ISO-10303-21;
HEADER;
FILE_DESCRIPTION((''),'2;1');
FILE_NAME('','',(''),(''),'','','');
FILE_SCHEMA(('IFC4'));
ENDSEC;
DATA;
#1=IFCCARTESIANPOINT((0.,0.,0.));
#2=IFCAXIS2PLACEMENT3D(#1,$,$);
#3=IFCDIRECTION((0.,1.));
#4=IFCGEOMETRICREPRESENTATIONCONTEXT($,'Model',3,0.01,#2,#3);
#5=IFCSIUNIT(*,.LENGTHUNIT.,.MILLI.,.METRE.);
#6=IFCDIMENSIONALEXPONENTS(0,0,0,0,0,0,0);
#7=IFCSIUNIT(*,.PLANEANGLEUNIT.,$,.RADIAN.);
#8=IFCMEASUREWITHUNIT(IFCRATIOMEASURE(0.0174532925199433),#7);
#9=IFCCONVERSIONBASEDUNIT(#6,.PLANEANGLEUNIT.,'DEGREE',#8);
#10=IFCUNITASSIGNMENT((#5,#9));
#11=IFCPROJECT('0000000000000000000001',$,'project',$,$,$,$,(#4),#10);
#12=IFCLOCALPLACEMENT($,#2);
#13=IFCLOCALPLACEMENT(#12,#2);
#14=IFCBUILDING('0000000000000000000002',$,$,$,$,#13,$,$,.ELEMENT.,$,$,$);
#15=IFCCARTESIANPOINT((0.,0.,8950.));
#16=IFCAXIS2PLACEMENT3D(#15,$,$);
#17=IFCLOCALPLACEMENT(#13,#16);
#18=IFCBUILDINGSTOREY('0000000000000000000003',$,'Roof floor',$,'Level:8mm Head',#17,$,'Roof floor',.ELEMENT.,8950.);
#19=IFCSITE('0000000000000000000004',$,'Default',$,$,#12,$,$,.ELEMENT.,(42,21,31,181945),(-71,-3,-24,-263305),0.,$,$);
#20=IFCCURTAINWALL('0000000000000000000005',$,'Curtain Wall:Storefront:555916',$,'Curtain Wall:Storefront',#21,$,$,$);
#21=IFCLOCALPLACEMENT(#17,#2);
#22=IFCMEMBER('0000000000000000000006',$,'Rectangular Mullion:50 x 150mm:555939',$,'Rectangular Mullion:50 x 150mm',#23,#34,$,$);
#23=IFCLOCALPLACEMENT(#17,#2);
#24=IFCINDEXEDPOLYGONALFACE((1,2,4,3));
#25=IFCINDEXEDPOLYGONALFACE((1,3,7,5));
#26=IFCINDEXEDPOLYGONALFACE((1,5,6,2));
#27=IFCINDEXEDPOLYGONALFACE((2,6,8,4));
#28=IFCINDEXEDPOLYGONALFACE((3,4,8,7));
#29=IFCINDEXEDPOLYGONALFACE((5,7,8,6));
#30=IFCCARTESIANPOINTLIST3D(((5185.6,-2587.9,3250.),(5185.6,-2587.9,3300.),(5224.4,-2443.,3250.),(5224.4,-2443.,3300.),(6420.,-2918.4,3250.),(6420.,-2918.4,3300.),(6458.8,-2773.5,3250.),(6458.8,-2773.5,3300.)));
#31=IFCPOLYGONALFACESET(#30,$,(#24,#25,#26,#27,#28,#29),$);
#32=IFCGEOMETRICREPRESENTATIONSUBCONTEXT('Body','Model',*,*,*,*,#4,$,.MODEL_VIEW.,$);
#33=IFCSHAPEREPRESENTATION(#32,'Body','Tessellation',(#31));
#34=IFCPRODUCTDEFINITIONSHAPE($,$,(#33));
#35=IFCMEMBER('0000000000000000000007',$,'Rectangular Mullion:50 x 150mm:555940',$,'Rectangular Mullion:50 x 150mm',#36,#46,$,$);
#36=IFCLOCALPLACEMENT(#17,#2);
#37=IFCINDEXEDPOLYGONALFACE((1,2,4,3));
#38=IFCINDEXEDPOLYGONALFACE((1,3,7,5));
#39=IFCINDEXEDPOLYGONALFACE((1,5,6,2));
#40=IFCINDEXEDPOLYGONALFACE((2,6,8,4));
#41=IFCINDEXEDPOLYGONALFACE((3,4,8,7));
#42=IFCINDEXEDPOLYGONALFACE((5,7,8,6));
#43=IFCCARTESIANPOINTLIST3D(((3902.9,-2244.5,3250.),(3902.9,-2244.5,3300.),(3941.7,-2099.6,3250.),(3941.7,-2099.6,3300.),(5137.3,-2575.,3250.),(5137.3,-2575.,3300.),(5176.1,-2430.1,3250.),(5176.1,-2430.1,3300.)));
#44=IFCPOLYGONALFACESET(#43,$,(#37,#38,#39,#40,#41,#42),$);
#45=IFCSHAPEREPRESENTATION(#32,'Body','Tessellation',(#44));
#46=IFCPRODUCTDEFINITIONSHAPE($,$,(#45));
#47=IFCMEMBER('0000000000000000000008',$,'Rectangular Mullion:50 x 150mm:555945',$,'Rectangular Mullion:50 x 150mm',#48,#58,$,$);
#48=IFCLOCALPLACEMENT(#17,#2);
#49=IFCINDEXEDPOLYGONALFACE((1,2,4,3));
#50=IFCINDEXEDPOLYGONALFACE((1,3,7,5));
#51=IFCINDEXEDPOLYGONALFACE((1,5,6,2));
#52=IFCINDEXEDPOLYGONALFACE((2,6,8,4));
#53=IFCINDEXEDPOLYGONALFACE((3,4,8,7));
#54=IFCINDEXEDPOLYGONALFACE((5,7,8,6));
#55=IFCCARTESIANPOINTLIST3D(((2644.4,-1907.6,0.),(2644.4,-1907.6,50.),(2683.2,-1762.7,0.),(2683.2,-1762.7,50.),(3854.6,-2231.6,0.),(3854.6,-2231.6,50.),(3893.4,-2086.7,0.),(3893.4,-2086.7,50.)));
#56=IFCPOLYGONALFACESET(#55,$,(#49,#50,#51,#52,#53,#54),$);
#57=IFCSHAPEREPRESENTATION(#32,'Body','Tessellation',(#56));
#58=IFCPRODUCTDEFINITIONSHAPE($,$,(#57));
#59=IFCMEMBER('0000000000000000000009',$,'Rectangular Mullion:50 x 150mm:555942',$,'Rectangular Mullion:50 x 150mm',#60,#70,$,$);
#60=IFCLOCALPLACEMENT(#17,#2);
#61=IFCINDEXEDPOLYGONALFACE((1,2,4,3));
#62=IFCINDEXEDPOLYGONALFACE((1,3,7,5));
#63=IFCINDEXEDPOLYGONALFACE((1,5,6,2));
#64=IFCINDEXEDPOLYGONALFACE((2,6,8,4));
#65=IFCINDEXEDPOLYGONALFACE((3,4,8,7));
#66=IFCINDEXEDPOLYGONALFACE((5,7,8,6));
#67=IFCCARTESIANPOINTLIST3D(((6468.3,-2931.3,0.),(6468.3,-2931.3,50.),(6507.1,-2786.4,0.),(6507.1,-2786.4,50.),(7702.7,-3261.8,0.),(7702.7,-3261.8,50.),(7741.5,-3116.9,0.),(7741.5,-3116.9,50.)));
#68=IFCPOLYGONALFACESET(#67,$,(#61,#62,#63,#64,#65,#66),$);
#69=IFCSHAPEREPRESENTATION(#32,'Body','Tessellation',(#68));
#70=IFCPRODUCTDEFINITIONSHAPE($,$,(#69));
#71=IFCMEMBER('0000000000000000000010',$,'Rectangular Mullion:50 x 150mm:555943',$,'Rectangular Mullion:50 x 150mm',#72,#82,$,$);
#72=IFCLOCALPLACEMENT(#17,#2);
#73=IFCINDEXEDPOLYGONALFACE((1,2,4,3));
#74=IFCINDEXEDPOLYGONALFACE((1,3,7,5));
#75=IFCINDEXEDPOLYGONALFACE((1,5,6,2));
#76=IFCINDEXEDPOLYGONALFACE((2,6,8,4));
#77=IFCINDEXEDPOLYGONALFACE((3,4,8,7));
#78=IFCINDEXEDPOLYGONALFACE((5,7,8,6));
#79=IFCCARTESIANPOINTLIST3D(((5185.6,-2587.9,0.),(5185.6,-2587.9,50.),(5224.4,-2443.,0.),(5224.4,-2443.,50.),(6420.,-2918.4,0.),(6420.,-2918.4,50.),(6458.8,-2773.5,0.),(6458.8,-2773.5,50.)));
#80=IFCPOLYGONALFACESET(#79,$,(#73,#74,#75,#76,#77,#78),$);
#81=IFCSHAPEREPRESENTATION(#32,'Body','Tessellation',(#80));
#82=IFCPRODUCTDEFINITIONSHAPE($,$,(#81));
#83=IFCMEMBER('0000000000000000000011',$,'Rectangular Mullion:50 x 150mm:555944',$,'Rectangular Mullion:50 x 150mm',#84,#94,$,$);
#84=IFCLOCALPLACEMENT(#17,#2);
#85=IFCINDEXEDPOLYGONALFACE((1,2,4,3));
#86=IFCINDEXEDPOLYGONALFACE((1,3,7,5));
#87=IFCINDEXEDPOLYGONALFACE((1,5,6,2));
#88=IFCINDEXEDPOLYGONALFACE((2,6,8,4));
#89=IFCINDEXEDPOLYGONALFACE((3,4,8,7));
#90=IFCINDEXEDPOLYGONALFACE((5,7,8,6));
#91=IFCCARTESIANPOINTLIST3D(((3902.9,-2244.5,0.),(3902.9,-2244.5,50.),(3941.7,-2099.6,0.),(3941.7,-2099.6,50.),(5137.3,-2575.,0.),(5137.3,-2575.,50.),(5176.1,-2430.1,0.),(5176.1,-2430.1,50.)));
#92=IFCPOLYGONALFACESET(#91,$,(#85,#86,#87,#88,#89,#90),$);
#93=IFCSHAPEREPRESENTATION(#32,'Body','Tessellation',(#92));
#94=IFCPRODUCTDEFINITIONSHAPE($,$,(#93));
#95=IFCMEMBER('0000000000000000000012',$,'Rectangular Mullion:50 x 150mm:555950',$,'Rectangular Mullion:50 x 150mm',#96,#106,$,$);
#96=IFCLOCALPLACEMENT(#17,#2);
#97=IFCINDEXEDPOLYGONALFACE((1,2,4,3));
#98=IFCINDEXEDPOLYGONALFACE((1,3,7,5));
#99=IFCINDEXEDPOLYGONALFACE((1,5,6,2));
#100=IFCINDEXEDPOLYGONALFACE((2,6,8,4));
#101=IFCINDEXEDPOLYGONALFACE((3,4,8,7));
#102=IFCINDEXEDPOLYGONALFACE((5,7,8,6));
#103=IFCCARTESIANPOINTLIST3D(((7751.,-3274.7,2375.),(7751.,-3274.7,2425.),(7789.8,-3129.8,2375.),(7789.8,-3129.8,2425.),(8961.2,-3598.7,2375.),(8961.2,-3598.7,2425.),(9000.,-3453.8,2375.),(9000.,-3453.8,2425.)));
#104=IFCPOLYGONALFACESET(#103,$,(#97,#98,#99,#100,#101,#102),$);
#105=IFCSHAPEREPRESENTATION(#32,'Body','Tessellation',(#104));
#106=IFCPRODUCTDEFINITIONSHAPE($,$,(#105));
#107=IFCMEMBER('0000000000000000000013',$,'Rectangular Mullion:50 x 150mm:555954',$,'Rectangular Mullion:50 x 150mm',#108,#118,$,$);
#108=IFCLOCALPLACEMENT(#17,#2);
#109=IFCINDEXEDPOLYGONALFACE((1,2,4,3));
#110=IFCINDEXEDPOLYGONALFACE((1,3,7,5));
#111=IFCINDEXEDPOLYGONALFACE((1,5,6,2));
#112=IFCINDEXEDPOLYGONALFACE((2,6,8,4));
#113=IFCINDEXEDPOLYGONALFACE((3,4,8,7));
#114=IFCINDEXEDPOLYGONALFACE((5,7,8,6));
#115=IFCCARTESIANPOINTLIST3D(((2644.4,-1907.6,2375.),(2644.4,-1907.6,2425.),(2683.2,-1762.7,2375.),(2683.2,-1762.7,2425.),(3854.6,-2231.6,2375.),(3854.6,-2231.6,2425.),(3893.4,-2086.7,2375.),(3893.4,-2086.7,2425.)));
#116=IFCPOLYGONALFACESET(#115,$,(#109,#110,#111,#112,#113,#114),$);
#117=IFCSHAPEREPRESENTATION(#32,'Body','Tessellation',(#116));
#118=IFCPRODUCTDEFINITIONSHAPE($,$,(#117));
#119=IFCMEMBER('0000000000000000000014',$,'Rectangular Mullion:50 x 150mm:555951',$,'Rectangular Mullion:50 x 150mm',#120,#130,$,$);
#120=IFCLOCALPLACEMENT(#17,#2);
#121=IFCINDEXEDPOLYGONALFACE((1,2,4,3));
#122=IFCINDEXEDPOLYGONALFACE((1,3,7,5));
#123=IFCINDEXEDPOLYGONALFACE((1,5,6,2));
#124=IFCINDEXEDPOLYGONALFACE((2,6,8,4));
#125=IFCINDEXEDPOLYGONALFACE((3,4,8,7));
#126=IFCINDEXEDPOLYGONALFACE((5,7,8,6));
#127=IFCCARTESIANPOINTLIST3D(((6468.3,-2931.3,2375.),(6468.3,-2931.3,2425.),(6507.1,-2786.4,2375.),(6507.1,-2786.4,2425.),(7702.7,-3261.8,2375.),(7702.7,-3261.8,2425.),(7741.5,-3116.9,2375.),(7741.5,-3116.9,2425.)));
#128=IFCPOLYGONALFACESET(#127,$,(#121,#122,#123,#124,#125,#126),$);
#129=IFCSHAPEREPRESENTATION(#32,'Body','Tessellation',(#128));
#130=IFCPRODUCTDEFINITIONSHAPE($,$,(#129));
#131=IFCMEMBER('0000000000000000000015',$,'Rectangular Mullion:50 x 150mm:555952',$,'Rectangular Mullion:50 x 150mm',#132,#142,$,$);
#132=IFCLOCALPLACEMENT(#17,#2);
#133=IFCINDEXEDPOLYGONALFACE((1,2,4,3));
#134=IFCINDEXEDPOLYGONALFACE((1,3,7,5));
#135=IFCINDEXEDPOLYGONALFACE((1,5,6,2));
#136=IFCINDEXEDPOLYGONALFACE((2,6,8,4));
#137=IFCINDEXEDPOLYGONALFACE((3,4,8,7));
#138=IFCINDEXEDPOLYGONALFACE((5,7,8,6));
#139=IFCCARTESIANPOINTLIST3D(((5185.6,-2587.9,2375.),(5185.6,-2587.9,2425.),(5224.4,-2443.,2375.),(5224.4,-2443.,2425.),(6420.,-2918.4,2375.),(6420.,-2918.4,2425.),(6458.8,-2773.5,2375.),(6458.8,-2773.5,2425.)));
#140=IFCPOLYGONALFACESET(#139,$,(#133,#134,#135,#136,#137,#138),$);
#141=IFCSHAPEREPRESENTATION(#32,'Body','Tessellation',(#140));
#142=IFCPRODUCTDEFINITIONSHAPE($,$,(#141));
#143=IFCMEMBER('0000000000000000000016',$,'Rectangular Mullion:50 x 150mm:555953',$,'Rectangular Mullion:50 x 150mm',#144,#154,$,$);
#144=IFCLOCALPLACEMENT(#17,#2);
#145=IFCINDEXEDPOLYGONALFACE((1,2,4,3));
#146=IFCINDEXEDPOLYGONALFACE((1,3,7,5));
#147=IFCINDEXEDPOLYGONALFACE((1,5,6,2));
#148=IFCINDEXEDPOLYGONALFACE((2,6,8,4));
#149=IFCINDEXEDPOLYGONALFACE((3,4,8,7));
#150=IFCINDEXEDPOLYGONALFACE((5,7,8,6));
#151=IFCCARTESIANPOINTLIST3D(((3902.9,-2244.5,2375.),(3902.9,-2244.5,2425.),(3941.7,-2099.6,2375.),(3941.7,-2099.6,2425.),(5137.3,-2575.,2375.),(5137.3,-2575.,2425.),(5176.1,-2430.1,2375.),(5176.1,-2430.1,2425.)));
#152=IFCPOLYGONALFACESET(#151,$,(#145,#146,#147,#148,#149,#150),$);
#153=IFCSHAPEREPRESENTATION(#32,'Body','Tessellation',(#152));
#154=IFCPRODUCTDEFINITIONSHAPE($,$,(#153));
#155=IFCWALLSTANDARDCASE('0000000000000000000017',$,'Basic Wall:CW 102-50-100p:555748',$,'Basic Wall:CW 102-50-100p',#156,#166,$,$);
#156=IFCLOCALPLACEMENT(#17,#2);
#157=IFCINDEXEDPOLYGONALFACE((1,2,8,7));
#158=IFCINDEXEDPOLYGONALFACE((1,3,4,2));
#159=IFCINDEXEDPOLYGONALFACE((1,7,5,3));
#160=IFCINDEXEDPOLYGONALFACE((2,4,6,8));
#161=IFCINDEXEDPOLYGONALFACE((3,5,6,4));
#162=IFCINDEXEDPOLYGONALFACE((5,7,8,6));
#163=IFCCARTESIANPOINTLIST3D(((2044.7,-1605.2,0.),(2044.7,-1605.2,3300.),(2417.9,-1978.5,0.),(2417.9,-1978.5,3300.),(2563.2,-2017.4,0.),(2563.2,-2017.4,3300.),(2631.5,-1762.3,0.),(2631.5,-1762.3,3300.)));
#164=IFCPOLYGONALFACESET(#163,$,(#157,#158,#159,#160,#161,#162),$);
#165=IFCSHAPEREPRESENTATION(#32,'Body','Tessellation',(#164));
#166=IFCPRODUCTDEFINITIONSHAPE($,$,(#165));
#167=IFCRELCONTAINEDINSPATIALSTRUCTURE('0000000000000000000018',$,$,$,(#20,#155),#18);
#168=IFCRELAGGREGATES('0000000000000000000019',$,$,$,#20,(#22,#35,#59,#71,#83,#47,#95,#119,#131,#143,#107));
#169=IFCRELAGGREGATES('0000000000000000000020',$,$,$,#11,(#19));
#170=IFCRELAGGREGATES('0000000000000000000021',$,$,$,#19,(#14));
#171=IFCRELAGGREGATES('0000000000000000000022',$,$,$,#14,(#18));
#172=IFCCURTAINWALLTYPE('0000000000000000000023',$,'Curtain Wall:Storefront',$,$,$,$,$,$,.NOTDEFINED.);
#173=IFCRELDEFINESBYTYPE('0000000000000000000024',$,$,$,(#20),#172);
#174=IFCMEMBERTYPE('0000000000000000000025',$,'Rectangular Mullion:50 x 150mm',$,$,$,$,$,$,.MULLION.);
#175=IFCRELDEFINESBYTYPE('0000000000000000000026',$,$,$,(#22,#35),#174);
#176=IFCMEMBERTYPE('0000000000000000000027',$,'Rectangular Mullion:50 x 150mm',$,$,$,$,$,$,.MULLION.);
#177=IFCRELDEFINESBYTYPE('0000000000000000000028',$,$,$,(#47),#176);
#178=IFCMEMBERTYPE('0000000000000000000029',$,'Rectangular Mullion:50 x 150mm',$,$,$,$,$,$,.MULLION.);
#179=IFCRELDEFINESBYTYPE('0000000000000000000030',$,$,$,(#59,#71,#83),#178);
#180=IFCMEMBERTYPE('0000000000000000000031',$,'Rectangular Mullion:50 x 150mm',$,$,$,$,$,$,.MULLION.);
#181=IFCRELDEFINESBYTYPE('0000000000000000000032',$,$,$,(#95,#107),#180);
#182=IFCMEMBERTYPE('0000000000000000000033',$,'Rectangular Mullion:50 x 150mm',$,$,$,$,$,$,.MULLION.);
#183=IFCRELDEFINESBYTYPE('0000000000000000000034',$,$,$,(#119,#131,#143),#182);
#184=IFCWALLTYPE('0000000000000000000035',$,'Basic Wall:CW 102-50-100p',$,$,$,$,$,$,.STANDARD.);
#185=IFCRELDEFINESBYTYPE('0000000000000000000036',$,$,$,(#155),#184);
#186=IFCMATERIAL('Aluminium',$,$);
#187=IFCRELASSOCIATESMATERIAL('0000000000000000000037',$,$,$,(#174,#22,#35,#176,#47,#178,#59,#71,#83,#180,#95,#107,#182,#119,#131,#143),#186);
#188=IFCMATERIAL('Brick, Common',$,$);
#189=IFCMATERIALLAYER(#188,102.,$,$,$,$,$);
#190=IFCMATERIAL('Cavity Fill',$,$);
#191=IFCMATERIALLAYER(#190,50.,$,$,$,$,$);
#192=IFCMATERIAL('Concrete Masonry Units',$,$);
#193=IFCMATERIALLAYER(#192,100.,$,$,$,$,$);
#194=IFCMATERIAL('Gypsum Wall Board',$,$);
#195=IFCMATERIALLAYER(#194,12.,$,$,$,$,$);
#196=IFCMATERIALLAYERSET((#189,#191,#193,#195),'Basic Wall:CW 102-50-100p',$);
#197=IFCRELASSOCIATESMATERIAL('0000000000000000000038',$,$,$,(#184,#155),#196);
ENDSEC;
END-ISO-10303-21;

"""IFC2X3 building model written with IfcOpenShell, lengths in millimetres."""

from ifc_helpers import new_model, entity, si_unit, converted_unit, direction, frame, origin, origin_2d_with_axis, place, context, subcontext, project, spatial, polyline, rectangle, outline, extrude, source, transform, mapped, material, layer, layer_set, layer_usage, type_object, type_shapes, element, aggregate, save


model = new_model("IFC2X3")

# Units and contexts
model_context = context("Model", 3, precision=0.01, world=origin(), true_north=direction((0.0, 1.0)))
body_context = subcontext(model_context, "Body", "Model", "MODEL_VIEW")
ifc_project = project(units=[si_unit("LENGTHUNIT", "METRE", prefix="MILLI"), converted_unit("PLANEANGLEUNIT", "DEGREE", entity("IfcRatioMeasure", 0.0174532925199433), si_unit("PLANEANGLEUNIT", "RADIAN"), dimensions=[0, 0, 0, 0, 0, 0, 0])], contexts=[model_context])

# Site, building, storey
site_placement = place(None, origin())
site = spatial("IfcSite", under=ifc_project, at=site_placement, Name="Default", CompositionType="ELEMENT", RefLatitude=(42, 21, 31, 181945), RefLongitude=(-71, -3, -24, -263305), RefElevation=0.0)
building_placement = place(site_placement, origin())
building = spatial("IfcBuilding", under=site, at=building_placement, CompositionType="ELEMENT")
storey_placement = place(building_placement, frame((0.0, 0.0, 8950.0)))
storey = spatial("IfcBuildingStorey", under=building, at=storey_placement, Name="Roof floor", ObjectType="Level:8mm Head", LongName="Roof floor", CompositionType="ELEMENT", Elevation=8950.0)

# Curtain wall, members
curtain_wall_type = type_object("IfcCurtainWallType", Name="Curtain Wall:Storefront", PredefinedType="NOTDEFINED")
curtain_wall_placement = place(storey_placement, frame((0.0, 0.0, -8950.0)))
curtain_wall = element("IfcCurtainWall", 1, at=curtain_wall_placement, inside=storey, type_object=curtain_wall_type, Name="Curtain Wall:Storefront:555916", ObjectType="Curtain Wall:Storefront")
ifc_material_1 = material(Name="Aluminium")
member_type_1 = type_object("IfcMemberType", Name="Rectangular Mullion:50 x 150mm", PredefinedType="MULLION", material=ifc_material_1)
shared_shape_1 = source(origin(), body_context, "Body", "SweptSolid", [
    extrude(rectangle(XDim=150.0, YDim=50.0, at=origin_2d_with_axis()), frame((-25.0, 0.0, -1277.9), z_axis=(0.0, 0.0, 1.0), x_axis=(0.0, -1.0, 0.0)), (0.0, 0.0, 1.0), 1277.9),
])
type_shapes(member_type_1, [shared_shape_1])
member_1_placement = place(storey_placement, frame((5205.0, -2515.5, 3300.0), z_axis=(-0.965983, 0.258607, 0.0), x_axis=(0.0, 0.0, 1.0)))
member_1 = element("IfcMember", 2, at=member_1_placement, type_object=member_type_1, material=ifc_material_1, Name="Rectangular Mullion:50 x 150mm:555939", ObjectType="Rectangular Mullion:50 x 150mm", context=body_context, shape_type="MappedRepresentation", body=[
    mapped(shared_shape_1, transform((0.0, 0.0, 0.0), scale=1.0)),
])
member_2_placement = place(storey_placement, frame((3922.3, -2172.1, 3300.0), z_axis=(-0.965983, 0.258607, 0.0), x_axis=(0.0, 0.0, 1.0)))
member_2 = element("IfcMember", 3, at=member_2_placement, type_object=member_type_1, material=ifc_material_1, Name="Rectangular Mullion:50 x 150mm:555940", ObjectType="Rectangular Mullion:50 x 150mm", context=body_context, shape_type="MappedRepresentation", body=[
    mapped(shared_shape_1, transform((0.0, 0.0, 0.0), scale=1.0)),
])
member_type_2 = type_object("IfcMemberType", Name="Rectangular Mullion:50 x 150mm", PredefinedType="MULLION", material=ifc_material_1)
shared_shape_2 = source(origin(), body_context, "Body", "SweptSolid", [
    extrude(rectangle(XDim=150.0, YDim=50.0, at=origin_2d_with_axis()), frame((-25.0, 0.0, -1252.9), z_axis=(0.0, 0.0, 1.0), x_axis=(0.0, -1.0, 0.0)), (0.0, 0.0, 1.0), 1252.9),
])
type_shapes(member_type_2, [shared_shape_2])
member_3_placement = place(storey_placement, frame((3874.0, -2159.1, 0.0), z_axis=(0.965983, -0.258607, 0.0), x_axis=(0.0, 0.0, -1.0)))
member_3 = element("IfcMember", 4, at=member_3_placement, type_object=member_type_2, material=ifc_material_1, Name="Rectangular Mullion:50 x 150mm:555945", ObjectType="Rectangular Mullion:50 x 150mm", context=body_context, shape_type="MappedRepresentation", body=[
    mapped(shared_shape_2, transform((0.0, 0.0, 0.0), scale=1.0)),
])
member_type_3 = type_object("IfcMemberType", Name="Rectangular Mullion:50 x 150mm", PredefinedType="MULLION", material=ifc_material_1)
shared_shape_3 = source(origin(), body_context, "Body", "SweptSolid", [
    extrude(rectangle(XDim=150.0, YDim=50.0, at=origin_2d_with_axis()), frame((-25.0, 0.0, -1277.9), z_axis=(0.0, 0.0, 1.0), x_axis=(0.0, -1.0, 0.0)), (0.0, 0.0, 1.0), 1277.9),
])
type_shapes(member_type_3, [shared_shape_3])
member_4_placement = place(storey_placement, frame((7722.1, -3189.3, 0.0), z_axis=(0.965983, -0.258607, 0.0), x_axis=(0.0, 0.0, -1.0)))
member_4 = element("IfcMember", 5, at=member_4_placement, type_object=member_type_3, material=ifc_material_1, Name="Rectangular Mullion:50 x 150mm:555942", ObjectType="Rectangular Mullion:50 x 150mm", context=body_context, shape_type="MappedRepresentation", body=[
    mapped(shared_shape_3, transform((0.0, 0.0, 0.0), scale=1.0)),
])
member_5_placement = place(storey_placement, frame((6439.4, -2845.9, 0.0), z_axis=(0.965983, -0.258607, 0.0), x_axis=(0.0, 0.0, -1.0)))
member_5 = element("IfcMember", 6, at=member_5_placement, type_object=member_type_3, material=ifc_material_1, Name="Rectangular Mullion:50 x 150mm:555943", ObjectType="Rectangular Mullion:50 x 150mm", context=body_context, shape_type="MappedRepresentation", body=[
    mapped(shared_shape_3, transform((0.0, 0.0, 0.0), scale=1.0)),
])
member_6_placement = place(storey_placement, frame((5156.7, -2502.5, 0.0), z_axis=(0.965983, -0.258607, 0.0), x_axis=(0.0, 0.0, -1.0)))
member_6 = element("IfcMember", 7, at=member_6_placement, type_object=member_type_3, material=ifc_material_1, Name="Rectangular Mullion:50 x 150mm:555944", ObjectType="Rectangular Mullion:50 x 150mm", context=body_context, shape_type="MappedRepresentation", body=[
    mapped(shared_shape_3, transform((0.0, 0.0, 0.0), scale=1.0)),
])
member_type_4 = type_object("IfcMemberType", Name="Rectangular Mullion:50 x 150mm", PredefinedType="MULLION", material=ifc_material_1)
shared_shape_4 = source(origin(), body_context, "Body", "SweptSolid", [
    extrude(rectangle(XDim=150.0, YDim=50.0, at=origin_2d_with_axis()), frame((0.0, 0.0, -1252.9), z_axis=(0.0, 0.0, 1.0), x_axis=(0.0, -1.0, 0.0)), (0.0, 0.0, 1.0), 1252.9),
])
type_shapes(member_type_4, [shared_shape_4])
member_7_placement = place(storey_placement, frame((7770.4, -3202.3, 2400.0), z_axis=(-0.965983, 0.258607, 0.0), x_axis=(0.0, 0.0, 1.0)))
member_7 = element("IfcMember", 8, at=member_7_placement, type_object=member_type_4, material=ifc_material_1, Name="Rectangular Mullion:50 x 150mm:555950", ObjectType="Rectangular Mullion:50 x 150mm", context=body_context, shape_type="MappedRepresentation", body=[
    mapped(shared_shape_4, transform((0.0, 0.0, 0.0), scale=1.0)),
])
member_8_placement = place(storey_placement, frame((2663.8, -1835.1, 2400.0), z_axis=(-0.965983, 0.258607, 0.0), x_axis=(0.0, 0.0, 1.0)))
member_8 = element("IfcMember", 9, at=member_8_placement, type_object=member_type_4, material=ifc_material_1, Name="Rectangular Mullion:50 x 150mm:555954", ObjectType="Rectangular Mullion:50 x 150mm", context=body_context, shape_type="MappedRepresentation", body=[
    mapped(shared_shape_4, transform((0.0, 0.0, 0.0), scale=1.0)),
])
member_type_5 = type_object("IfcMemberType", Name="Rectangular Mullion:50 x 150mm", PredefinedType="MULLION", material=ifc_material_1)
shared_shape_5 = source(origin(), body_context, "Body", "SweptSolid", [
    extrude(rectangle(XDim=150.0, YDim=50.0, at=origin_2d_with_axis()), frame((0.0, 0.0, -1277.9), z_axis=(0.0, 0.0, 1.0), x_axis=(0.0, -1.0, 0.0)), (0.0, 0.0, 1.0), 1277.9),
])
type_shapes(member_type_5, [shared_shape_5])
member_9_placement = place(storey_placement, frame((6487.7, -2858.9, 2400.0), z_axis=(-0.965983, 0.258607, 0.0), x_axis=(0.0, 0.0, 1.0)))
member_9 = element("IfcMember", 10, at=member_9_placement, type_object=member_type_5, material=ifc_material_1, Name="Rectangular Mullion:50 x 150mm:555951", ObjectType="Rectangular Mullion:50 x 150mm", context=body_context, shape_type="MappedRepresentation", body=[
    mapped(shared_shape_5, transform((0.0, 0.0, 0.0), scale=1.0)),
])
member_10_placement = place(storey_placement, frame((5205.0, -2515.5, 2400.0), z_axis=(-0.965983, 0.258607, 0.0), x_axis=(0.0, 0.0, 1.0)))
member_10 = element("IfcMember", 11, at=member_10_placement, type_object=member_type_5, material=ifc_material_1, Name="Rectangular Mullion:50 x 150mm:555952", ObjectType="Rectangular Mullion:50 x 150mm", context=body_context, shape_type="MappedRepresentation", body=[
    mapped(shared_shape_5, transform((0.0, 0.0, 0.0), scale=1.0)),
])
member_11_placement = place(storey_placement, frame((3922.3, -2172.1, 2400.0), z_axis=(-0.965983, 0.258607, 0.0), x_axis=(0.0, 0.0, 1.0)))
member_11 = element("IfcMember", 12, at=member_11_placement, type_object=member_type_5, material=ifc_material_1, Name="Rectangular Mullion:50 x 150mm:555953", ObjectType="Rectangular Mullion:50 x 150mm", context=body_context, shape_type="MappedRepresentation", body=[
    mapped(shared_shape_5, transform((0.0, 0.0, 0.0), scale=1.0)),
])
aggregate(curtain_wall, [member_1, member_2, member_4, member_5, member_6, member_3, member_7, member_9, member_10, member_11, member_8])

# Wall
ifc_material_2 = material(Name="Brick, Common")
ifc_layer_1 = layer(ifc_material_2, 102.0)
ifc_material_3 = material(Name="Cavity Fill")
ifc_layer_2 = layer(ifc_material_3, 50.0)
ifc_material_4 = material(Name="Concrete Masonry Units")
ifc_layer_3 = layer(ifc_material_4, 100.0)
ifc_material_5 = material(Name="Gypsum Wall Board")
ifc_layer_4 = layer(ifc_material_5, 12.0)
ifc_layer_set_1 = layer_set([ifc_layer_1, ifc_layer_2, ifc_layer_3, ifc_layer_4], Name="Basic Wall:CW 102-50-100p")
ifc_layer_usage_1 = layer_usage(ifc_layer_set_1, "AXIS2", "NEGATIVE", 132.0)
wall_type_1 = type_object("IfcWallType", Name="Basic Wall:CW 102-50-100p", PredefinedType="STANDARD", material=ifc_layer_set_1)
wall_1_placement = place(storey_placement, frame((2597.4, -1889.8, 0.0), z_axis=(0.0, 0.0, 1.0), x_axis=(-0.965983, 0.258607, 0.0)))
element("IfcWallStandardCase", 13, at=wall_1_placement, inside=storey, type_object=wall_type_1, material=ifc_layer_usage_1, Name="Basic Wall:CW 102-50-100p:555748", ObjectType="Basic Wall:CW 102-50-100p", context=body_context, shape_type="SweptSolid", body=[
    extrude(outline(polyline([(607.4, -132.0), (150.4, 132.0), (0.0, 132.0), (0.0, -132.0), (607.4, -132.0)])), origin(), (0.0, 0.0, 1.0), 3300.0),
])

save(model, "model.ifc")
